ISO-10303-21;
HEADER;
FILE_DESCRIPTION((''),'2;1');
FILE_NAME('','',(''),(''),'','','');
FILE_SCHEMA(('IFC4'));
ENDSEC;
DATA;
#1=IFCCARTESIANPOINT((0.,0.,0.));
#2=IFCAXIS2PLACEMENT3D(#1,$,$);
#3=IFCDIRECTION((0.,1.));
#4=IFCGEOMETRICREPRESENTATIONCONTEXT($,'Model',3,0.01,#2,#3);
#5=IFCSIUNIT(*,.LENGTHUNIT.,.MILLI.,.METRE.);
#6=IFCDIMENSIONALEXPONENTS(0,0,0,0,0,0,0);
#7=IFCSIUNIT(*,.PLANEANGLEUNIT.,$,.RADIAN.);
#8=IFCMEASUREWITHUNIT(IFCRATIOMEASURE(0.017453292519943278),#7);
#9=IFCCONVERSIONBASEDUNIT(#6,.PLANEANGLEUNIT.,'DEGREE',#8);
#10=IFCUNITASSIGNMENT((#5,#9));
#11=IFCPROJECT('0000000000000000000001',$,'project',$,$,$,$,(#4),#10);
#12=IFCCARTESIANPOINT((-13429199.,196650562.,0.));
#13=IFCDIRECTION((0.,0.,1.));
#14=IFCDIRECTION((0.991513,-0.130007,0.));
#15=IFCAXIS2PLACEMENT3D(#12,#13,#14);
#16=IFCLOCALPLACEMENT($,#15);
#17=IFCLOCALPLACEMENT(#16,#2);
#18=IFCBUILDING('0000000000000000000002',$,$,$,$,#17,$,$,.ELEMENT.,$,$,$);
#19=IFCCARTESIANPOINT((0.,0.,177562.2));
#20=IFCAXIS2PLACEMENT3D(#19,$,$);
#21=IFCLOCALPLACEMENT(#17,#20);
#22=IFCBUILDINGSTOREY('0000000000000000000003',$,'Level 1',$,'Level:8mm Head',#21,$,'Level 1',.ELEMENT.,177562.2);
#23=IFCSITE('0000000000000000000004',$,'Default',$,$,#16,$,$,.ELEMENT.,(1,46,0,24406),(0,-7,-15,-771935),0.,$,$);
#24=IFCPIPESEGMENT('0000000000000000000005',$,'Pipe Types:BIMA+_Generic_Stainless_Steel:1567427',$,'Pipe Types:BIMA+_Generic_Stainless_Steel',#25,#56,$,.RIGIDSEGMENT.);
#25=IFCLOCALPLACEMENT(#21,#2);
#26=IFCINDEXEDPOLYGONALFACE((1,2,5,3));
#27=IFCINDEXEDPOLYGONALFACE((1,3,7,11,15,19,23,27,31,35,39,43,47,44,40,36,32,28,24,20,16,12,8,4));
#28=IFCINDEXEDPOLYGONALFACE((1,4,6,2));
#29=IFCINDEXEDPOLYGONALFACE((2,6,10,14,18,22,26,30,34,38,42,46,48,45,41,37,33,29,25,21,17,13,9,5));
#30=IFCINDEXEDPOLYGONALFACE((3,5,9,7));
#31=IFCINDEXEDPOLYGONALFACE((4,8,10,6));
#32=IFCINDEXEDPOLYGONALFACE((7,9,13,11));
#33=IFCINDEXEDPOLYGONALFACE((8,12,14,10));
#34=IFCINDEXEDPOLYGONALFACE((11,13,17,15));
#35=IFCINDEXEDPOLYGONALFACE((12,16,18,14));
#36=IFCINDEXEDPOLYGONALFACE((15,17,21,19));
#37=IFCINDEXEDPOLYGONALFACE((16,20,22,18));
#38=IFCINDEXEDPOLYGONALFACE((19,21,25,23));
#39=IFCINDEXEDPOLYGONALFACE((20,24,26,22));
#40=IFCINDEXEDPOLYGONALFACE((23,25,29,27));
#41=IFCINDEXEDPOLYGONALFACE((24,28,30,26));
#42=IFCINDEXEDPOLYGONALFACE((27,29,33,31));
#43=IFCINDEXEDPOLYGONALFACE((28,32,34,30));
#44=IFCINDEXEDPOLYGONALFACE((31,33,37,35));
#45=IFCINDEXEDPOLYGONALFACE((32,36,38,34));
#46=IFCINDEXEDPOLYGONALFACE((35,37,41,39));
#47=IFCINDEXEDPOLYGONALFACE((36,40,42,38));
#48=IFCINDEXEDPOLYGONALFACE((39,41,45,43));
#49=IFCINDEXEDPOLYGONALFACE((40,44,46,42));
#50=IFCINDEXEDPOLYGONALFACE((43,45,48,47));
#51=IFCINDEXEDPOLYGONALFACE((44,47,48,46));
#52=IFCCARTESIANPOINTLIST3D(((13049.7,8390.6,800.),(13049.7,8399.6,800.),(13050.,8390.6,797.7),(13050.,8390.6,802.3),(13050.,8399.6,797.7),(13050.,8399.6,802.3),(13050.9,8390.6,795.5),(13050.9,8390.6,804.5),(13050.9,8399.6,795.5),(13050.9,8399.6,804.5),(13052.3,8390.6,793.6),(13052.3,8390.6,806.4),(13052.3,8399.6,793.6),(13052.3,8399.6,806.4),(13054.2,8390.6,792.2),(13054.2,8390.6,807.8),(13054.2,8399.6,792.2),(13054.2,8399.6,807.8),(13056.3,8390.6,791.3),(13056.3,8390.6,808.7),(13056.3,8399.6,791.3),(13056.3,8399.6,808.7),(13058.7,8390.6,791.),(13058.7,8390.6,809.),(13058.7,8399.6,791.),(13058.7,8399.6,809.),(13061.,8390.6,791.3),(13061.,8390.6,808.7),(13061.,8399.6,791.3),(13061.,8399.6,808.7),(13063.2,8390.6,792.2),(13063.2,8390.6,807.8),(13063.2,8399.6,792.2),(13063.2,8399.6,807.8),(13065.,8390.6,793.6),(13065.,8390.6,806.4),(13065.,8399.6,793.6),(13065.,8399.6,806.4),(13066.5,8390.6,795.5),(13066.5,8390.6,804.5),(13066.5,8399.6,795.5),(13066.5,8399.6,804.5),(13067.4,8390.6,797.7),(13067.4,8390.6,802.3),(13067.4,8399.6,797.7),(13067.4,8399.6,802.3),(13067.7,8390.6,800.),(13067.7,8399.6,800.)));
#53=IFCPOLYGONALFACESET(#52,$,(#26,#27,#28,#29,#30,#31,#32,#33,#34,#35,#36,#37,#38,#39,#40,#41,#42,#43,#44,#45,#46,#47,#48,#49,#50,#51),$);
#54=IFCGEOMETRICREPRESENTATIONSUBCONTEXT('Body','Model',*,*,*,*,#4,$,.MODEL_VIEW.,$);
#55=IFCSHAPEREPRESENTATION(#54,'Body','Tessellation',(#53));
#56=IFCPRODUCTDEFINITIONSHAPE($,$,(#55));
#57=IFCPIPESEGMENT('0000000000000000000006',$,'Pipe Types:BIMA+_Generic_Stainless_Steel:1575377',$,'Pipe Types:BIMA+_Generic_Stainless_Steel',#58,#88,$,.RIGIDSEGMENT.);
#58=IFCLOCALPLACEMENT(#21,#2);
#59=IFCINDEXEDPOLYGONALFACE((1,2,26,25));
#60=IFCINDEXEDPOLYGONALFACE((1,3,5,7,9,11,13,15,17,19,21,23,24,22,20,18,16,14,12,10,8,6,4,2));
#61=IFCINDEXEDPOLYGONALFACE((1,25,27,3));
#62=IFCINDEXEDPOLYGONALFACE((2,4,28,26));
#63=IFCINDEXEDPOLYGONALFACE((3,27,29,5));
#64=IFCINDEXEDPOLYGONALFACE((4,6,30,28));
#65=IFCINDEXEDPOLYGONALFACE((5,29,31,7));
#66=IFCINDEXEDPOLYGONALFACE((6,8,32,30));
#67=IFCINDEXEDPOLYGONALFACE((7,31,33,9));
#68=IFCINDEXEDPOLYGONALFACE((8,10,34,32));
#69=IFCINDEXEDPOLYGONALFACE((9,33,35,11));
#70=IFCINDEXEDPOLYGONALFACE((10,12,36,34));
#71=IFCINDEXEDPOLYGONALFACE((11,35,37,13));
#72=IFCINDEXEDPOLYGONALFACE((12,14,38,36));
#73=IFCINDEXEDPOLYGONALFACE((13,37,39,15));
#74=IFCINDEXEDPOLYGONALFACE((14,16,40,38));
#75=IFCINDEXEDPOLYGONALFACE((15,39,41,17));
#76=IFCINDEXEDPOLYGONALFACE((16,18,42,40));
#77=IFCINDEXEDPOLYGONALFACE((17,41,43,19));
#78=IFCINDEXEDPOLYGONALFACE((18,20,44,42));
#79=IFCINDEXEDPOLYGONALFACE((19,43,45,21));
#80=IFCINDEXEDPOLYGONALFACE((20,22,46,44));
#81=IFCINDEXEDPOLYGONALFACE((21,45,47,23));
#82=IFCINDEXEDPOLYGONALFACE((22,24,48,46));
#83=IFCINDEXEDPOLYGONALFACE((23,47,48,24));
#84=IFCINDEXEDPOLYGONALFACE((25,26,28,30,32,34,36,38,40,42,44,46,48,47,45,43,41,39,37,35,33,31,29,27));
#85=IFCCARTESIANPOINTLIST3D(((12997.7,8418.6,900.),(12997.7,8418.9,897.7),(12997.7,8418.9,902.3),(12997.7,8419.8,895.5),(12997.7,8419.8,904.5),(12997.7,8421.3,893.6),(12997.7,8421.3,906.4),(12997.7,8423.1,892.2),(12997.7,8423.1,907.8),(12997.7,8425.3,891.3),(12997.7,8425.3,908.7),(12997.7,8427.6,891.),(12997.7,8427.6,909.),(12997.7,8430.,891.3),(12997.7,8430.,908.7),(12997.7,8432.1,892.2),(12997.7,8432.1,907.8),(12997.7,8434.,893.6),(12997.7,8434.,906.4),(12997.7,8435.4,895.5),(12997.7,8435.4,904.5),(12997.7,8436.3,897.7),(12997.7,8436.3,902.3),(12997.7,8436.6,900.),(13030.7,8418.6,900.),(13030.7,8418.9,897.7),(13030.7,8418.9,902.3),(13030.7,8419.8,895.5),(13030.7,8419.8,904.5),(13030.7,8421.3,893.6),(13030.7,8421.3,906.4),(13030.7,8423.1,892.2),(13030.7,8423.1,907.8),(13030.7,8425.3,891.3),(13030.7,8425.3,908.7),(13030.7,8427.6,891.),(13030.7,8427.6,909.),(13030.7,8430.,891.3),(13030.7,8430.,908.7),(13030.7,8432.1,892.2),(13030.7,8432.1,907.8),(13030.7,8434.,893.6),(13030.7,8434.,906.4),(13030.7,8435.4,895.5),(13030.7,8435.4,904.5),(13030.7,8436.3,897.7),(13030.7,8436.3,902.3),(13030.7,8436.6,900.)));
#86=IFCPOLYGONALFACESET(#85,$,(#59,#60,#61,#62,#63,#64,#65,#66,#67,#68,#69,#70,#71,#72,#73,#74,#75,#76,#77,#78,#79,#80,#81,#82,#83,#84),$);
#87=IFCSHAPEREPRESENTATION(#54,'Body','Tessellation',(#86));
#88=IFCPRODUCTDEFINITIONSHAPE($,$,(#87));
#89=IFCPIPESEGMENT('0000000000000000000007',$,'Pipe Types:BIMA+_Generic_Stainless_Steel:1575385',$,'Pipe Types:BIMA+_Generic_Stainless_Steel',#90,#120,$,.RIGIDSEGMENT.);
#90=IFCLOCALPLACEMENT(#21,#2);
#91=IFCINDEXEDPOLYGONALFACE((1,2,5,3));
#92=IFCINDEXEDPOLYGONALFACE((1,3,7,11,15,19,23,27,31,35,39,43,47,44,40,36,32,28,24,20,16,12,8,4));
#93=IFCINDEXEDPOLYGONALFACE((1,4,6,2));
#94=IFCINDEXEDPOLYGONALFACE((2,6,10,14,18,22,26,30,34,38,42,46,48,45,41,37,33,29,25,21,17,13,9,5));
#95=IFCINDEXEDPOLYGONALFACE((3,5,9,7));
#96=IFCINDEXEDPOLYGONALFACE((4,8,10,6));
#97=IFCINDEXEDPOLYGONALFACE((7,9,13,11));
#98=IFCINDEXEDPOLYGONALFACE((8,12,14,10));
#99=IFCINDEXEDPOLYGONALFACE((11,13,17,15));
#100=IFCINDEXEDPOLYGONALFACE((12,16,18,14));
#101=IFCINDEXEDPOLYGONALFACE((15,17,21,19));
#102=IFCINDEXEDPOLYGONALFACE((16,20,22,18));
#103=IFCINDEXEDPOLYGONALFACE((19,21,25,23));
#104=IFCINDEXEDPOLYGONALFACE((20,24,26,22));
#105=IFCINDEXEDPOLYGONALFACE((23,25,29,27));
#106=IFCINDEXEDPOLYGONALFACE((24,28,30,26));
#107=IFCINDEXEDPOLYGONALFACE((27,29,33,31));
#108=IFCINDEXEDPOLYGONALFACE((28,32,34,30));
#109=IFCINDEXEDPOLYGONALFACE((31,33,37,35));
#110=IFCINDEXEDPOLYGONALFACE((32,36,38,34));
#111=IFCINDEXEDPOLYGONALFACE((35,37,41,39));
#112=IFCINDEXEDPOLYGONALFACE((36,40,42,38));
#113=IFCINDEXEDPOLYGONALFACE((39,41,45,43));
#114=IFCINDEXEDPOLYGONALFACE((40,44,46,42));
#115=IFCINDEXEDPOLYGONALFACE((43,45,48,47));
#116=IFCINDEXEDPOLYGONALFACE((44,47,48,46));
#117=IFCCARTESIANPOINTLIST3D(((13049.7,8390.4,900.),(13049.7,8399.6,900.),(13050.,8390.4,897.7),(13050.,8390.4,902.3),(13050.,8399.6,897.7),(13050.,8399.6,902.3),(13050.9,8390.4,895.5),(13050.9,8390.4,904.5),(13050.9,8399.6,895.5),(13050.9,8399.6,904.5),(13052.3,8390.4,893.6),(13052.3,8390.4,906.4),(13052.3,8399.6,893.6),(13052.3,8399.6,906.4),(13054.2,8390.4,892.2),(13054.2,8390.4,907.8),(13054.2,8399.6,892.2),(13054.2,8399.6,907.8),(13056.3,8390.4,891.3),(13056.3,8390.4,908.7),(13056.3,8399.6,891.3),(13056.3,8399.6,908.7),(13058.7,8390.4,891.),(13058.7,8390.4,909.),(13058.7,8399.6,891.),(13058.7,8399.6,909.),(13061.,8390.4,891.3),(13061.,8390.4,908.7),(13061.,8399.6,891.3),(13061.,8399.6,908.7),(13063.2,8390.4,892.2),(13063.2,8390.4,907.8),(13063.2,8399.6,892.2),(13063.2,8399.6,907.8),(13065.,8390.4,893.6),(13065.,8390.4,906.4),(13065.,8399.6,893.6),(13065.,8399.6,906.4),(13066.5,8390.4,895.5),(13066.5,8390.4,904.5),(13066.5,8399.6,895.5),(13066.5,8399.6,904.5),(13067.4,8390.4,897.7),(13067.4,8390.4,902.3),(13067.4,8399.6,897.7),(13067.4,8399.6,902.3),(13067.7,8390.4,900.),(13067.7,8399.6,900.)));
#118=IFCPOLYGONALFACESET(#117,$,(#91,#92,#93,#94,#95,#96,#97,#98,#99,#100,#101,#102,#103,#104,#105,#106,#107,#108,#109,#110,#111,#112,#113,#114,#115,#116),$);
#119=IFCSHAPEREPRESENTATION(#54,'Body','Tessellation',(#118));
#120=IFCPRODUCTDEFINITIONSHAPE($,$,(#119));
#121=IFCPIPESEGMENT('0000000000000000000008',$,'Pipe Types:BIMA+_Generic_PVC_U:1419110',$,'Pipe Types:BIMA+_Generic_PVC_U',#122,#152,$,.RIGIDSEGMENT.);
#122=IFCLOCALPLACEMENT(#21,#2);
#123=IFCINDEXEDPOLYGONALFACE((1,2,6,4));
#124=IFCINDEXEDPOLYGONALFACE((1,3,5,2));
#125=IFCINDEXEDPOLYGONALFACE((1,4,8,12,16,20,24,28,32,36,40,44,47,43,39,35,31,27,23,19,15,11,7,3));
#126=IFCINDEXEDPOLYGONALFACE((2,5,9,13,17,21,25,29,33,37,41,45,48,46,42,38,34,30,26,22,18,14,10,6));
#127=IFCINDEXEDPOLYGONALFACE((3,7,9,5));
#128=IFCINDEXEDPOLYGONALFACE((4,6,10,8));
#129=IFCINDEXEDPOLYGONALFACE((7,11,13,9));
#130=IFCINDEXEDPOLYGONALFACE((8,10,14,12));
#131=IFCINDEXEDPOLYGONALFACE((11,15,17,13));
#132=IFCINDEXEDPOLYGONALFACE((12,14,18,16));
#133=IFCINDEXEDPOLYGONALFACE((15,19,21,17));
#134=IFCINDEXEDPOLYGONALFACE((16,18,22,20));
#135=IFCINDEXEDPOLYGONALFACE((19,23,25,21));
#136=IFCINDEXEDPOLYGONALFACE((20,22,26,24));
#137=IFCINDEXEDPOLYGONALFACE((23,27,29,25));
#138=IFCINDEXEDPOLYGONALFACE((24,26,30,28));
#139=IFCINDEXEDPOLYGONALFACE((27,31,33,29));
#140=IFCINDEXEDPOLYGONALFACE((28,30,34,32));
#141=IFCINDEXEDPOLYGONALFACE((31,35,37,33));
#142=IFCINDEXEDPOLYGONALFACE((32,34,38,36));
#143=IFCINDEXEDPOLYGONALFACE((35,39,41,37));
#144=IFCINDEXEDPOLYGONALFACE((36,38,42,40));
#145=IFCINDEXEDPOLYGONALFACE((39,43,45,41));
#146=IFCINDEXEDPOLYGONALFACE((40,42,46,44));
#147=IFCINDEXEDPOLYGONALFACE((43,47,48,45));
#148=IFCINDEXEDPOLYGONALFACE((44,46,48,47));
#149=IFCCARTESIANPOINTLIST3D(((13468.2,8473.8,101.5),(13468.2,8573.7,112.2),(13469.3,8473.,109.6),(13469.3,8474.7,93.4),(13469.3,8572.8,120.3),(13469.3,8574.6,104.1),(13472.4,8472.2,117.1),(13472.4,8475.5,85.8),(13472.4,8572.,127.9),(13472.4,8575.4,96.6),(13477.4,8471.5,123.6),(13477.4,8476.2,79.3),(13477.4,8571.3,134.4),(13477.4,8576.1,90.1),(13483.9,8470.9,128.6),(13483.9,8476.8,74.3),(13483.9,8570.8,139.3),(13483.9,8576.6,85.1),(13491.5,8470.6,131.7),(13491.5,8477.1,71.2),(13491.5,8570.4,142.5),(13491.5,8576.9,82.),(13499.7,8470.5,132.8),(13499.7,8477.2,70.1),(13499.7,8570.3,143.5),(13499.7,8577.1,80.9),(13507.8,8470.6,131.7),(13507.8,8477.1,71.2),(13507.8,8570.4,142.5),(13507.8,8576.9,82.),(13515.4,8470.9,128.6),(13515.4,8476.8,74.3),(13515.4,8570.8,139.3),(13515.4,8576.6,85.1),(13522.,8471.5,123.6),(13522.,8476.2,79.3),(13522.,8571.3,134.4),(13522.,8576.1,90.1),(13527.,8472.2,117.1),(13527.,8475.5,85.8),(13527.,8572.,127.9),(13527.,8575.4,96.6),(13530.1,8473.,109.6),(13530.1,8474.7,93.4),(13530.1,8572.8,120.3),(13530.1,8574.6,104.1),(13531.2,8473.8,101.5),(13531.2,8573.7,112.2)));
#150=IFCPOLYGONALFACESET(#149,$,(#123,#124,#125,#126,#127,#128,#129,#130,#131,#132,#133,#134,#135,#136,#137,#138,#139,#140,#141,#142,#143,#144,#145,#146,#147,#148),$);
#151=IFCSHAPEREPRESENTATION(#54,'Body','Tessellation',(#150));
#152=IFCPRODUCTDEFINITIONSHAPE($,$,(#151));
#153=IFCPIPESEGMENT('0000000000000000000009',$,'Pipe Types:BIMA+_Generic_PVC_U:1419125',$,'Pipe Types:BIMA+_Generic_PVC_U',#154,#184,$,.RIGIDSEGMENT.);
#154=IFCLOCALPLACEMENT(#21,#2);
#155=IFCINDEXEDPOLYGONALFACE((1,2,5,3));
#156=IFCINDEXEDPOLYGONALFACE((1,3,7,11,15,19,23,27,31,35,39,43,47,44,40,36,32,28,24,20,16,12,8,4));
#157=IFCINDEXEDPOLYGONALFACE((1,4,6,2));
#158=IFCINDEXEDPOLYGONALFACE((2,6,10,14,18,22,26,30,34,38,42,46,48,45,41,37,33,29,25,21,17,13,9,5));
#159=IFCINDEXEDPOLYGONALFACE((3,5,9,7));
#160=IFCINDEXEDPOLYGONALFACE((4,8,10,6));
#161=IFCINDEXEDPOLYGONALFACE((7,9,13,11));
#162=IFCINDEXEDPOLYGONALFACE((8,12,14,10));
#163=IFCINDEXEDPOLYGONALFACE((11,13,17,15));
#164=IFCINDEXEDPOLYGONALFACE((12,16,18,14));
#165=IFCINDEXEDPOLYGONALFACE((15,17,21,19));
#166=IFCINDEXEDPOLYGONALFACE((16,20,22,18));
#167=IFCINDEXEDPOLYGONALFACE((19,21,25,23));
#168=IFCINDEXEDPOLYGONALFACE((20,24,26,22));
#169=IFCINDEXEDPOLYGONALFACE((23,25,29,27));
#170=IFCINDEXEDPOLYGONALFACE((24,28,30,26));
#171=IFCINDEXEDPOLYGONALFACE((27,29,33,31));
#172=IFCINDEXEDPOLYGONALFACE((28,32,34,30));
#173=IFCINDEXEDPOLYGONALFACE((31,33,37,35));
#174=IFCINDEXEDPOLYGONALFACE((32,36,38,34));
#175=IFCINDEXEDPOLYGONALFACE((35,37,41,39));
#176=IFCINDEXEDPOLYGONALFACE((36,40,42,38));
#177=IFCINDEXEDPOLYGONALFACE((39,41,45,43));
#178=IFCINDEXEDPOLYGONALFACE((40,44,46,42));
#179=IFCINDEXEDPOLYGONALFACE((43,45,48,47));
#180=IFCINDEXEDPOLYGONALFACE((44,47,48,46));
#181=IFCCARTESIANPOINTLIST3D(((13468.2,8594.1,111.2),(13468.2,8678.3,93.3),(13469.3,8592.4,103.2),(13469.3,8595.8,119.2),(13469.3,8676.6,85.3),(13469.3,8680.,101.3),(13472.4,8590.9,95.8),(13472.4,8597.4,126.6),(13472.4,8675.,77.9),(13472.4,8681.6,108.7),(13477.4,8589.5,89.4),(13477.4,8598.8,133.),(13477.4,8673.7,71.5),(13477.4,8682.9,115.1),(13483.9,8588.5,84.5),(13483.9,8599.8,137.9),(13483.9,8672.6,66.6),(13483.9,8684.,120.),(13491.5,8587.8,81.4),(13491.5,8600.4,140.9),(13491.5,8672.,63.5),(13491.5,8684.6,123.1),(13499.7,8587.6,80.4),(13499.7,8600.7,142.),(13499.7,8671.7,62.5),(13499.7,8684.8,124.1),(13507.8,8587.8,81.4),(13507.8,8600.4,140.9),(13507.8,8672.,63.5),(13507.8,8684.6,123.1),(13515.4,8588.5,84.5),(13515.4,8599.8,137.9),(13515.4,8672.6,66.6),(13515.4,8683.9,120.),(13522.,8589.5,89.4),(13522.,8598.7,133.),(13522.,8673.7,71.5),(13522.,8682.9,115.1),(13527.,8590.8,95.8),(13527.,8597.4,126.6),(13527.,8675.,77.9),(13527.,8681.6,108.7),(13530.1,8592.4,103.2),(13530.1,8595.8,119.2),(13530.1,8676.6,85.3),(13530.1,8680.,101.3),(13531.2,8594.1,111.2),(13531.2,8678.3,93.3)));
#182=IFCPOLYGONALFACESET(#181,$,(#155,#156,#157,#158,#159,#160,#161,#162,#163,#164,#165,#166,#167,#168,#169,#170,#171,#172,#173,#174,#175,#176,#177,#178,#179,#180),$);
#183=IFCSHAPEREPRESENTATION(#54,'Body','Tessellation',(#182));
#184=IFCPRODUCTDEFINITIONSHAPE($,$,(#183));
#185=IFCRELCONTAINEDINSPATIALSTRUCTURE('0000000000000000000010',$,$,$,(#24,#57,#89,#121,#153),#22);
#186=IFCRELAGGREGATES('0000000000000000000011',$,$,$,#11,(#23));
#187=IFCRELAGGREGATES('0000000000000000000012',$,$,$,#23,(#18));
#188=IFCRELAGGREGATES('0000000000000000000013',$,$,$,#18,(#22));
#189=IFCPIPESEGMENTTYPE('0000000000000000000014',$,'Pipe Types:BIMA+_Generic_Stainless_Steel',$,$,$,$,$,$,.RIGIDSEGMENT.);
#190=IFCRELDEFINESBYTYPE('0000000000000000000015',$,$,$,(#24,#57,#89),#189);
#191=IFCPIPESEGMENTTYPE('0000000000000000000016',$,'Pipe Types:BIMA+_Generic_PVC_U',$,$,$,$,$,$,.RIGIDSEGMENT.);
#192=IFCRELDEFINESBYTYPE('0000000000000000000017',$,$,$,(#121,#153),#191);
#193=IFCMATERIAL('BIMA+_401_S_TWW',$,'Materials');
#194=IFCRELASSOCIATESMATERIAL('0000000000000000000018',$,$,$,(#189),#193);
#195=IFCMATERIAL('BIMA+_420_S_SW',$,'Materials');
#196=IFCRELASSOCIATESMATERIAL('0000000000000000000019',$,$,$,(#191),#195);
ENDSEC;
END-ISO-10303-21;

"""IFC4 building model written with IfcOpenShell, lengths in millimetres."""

from ifc_helpers import new_model, entity, si_unit, converted_unit, direction, frame, origin, place, context, subcontext, project, spatial, arc, indexed_curve, outline, extrude, material, type_object, element, save


model = new_model("IFC4")

# Units and contexts
model_context = context("Model", 3, precision=0.01, world=origin(), true_north=direction((0.0, 1.0)))
body_context = subcontext(model_context, "Body", "Model", "MODEL_VIEW")
ifc_project = project(units=[si_unit("LENGTHUNIT", "METRE", prefix="MILLI"), converted_unit("PLANEANGLEUNIT", "DEGREE", entity("IfcRatioMeasure", 0.017453292519943278), si_unit("PLANEANGLEUNIT", "RADIAN"), dimensions=[0, 0, 0, 0, 0, 0, 0])], contexts=[model_context])

# Site, building, storey
site_placement = place(None, frame((-13429199.0, 196650562.0, 0.0), z_axis=(0.0, 0.0, 1.0), x_axis=(0.991513, -0.130007, 0.0)))
site = spatial("IfcSite", under=ifc_project, at=site_placement, Name="Default", CompositionType="ELEMENT", RefLatitude=(1, 46, 0, 24406), RefLongitude=(0, -7, -15, -771935), RefElevation=0.0)
building_placement = place(site_placement, origin())
building = spatial("IfcBuilding", under=site, at=building_placement, CompositionType="ELEMENT")
storey_placement = place(building_placement, frame((0.0, 0.0, 177562.2)))
storey = spatial("IfcBuildingStorey", under=building, at=storey_placement, Name="Level 1", ObjectType="Level:8mm Head", LongName="Level 1", CompositionType="ELEMENT", Elevation=177562.2)

# Pipe segments
ifc_material_1 = material(Name="BIMA+_401_S_TWW", Category="Materials")
pipe_segment_type_1 = type_object("IfcPipeSegmentType", Name="Pipe Types:BIMA+_Generic_Stainless_Steel", PredefinedType="RIGIDSEGMENT", material=ifc_material_1)
pipe_segment_1_placement = place(storey_placement, frame((13048.1, 8390.6, 789.4)))
element("IfcPipeSegment", 1, at=pipe_segment_1_placement, inside=storey, type_object=pipe_segment_type_1, Name="Pipe Types:BIMA+_Generic_Stainless_Steel:1567427", ObjectType="Pipe Types:BIMA+_Generic_Stainless_Steel", PredefinedType="RIGIDSEGMENT", context=body_context, shape_type="SweptSolid", body=[
    extrude(outline(indexed_curve([(9.0, 0.0), (6.4, 6.4), (0.0, 9.0), (-6.4, 6.4), (-9.0, 0.0), (-6.4, -6.4), (0.0, -9.0), (6.4, -6.4)], segments=[arc(1, 2, 3), arc(3, 4, 5), arc(5, 6, 7), arc(7, 8, 1)], self_intersect=False)), frame((10.6, 0.0, 10.6), z_axis=(0.0, 1.0, 0.0), x_axis=(1.0, 0.0, 0.0)), (0.0, 0.0, 1.0), 9.0),
])
pipe_segment_2_placement = place(storey_placement, frame((12997.7, 8417.0, 889.4)))
element("IfcPipeSegment", 2, at=pipe_segment_2_placement, inside=storey, type_object=pipe_segment_type_1, Name="Pipe Types:BIMA+_Generic_Stainless_Steel:1575377", ObjectType="Pipe Types:BIMA+_Generic_Stainless_Steel", PredefinedType="RIGIDSEGMENT", context=body_context, shape_type="SweptSolid", body=[
    extrude(outline(indexed_curve([(9.0, 0.0), (6.4, 6.4), (0.0, 9.0), (-6.4, 6.4), (-9.0, 0.0), (-6.4, -6.4), (0.0, -9.0), (6.4, -6.4)], segments=[arc(1, 2, 3), arc(3, 4, 5), arc(5, 6, 7), arc(7, 8, 1)], self_intersect=False)), frame((0.0, 10.6, 10.6), z_axis=(1.0, 0.0, 0.0), x_axis=(0.0, -1.0, 0.0)), (0.0, 0.0, 1.0), 33.0),
])
pipe_segment_3_placement = place(storey_placement, frame((13048.1, 8390.4, 889.4)))
element("IfcPipeSegment", 3, at=pipe_segment_3_placement, inside=storey, type_object=pipe_segment_type_1, Name="Pipe Types:BIMA+_Generic_Stainless_Steel:1575385", ObjectType="Pipe Types:BIMA+_Generic_Stainless_Steel", PredefinedType="RIGIDSEGMENT", context=body_context, shape_type="SweptSolid", body=[
    extrude(outline(indexed_curve([(9.0, 0.0), (6.4, 6.4), (0.0, 9.0), (-6.4, 6.4), (-9.0, 0.0), (-6.4, -6.4), (0.0, -9.0), (6.4, -6.4)], segments=[arc(1, 2, 3), arc(3, 4, 5), arc(5, 6, 7), arc(7, 8, 1)], self_intersect=False)), frame((10.6, 0.0, 10.6), z_axis=(0.0, 1.0, 0.0), x_axis=(1.0, 0.0, 0.0)), (0.0, 0.0, 1.0), 9.2),
])
ifc_material_2 = material(Name="BIMA+_420_S_SW", Category="Materials")
pipe_segment_type_2 = type_object("IfcPipeSegmentType", Name="Pipe Types:BIMA+_Generic_PVC_U", PredefinedType="RIGIDSEGMENT", material=ifc_material_2)
pipe_segment_4_placement = place(storey_placement, frame((13466.6, 8468.9, 145.1)))
element("IfcPipeSegment", 4, at=pipe_segment_4_placement, inside=storey, type_object=pipe_segment_type_2, Name="Pipe Types:BIMA+_Generic_PVC_U:1419110", ObjectType="Pipe Types:BIMA+_Generic_PVC_U", PredefinedType="RIGIDSEGMENT", context=body_context, shape_type="SweptSolid", body=[
    extrude(outline(indexed_curve([(31.5, 0.0), (22.3, 22.3), (0.0, 31.5), (-22.3, 22.3), (-31.5, 0.0), (-22.3, -22.3), (0.0, -31.5), (22.3, -22.3)], segments=[arc(1, 2, 3), arc(3, 4, 5), arc(5, 6, 7), arc(7, 8, 1)], self_intersect=False)), frame((33.1, 5.0, -43.7), z_axis=(-0.000032, 0.994236, 0.107216), x_axis=(-1.0, -0.000032, 0.0)), (0.0, 0.0, 1.0), 100.4),
])
pipe_segment_5_placement = place(storey_placement, frame((13466.6, 8586.0, 143.6)))
element("IfcPipeSegment", 5, at=pipe_segment_5_placement, inside=storey, type_object=pipe_segment_type_2, Name="Pipe Types:BIMA+_Generic_PVC_U:1419125", ObjectType="Pipe Types:BIMA+_Generic_PVC_U", PredefinedType="RIGIDSEGMENT", context=body_context, shape_type="SweptSolid", body=[
    extrude(outline(indexed_curve([(31.5, 0.0), (22.3, 22.3), (0.0, 31.5), (-22.3, 22.3), (-31.5, 0.0), (-22.3, -22.3), (0.0, -31.5), (22.3, -22.3)], segments=[arc(1, 2, 3), arc(3, 4, 5), arc(5, 6, 7), arc(7, 8, 1)], self_intersect=False)), frame((33.1, 92.3, -50.3), z_axis=(-0.000061, -0.978185, 0.207737), x_axis=(-1.0, 0.000062, 0.0)), (0.0, 0.0, 1.0), 86.0),
])

save(model, "model.ifc")
